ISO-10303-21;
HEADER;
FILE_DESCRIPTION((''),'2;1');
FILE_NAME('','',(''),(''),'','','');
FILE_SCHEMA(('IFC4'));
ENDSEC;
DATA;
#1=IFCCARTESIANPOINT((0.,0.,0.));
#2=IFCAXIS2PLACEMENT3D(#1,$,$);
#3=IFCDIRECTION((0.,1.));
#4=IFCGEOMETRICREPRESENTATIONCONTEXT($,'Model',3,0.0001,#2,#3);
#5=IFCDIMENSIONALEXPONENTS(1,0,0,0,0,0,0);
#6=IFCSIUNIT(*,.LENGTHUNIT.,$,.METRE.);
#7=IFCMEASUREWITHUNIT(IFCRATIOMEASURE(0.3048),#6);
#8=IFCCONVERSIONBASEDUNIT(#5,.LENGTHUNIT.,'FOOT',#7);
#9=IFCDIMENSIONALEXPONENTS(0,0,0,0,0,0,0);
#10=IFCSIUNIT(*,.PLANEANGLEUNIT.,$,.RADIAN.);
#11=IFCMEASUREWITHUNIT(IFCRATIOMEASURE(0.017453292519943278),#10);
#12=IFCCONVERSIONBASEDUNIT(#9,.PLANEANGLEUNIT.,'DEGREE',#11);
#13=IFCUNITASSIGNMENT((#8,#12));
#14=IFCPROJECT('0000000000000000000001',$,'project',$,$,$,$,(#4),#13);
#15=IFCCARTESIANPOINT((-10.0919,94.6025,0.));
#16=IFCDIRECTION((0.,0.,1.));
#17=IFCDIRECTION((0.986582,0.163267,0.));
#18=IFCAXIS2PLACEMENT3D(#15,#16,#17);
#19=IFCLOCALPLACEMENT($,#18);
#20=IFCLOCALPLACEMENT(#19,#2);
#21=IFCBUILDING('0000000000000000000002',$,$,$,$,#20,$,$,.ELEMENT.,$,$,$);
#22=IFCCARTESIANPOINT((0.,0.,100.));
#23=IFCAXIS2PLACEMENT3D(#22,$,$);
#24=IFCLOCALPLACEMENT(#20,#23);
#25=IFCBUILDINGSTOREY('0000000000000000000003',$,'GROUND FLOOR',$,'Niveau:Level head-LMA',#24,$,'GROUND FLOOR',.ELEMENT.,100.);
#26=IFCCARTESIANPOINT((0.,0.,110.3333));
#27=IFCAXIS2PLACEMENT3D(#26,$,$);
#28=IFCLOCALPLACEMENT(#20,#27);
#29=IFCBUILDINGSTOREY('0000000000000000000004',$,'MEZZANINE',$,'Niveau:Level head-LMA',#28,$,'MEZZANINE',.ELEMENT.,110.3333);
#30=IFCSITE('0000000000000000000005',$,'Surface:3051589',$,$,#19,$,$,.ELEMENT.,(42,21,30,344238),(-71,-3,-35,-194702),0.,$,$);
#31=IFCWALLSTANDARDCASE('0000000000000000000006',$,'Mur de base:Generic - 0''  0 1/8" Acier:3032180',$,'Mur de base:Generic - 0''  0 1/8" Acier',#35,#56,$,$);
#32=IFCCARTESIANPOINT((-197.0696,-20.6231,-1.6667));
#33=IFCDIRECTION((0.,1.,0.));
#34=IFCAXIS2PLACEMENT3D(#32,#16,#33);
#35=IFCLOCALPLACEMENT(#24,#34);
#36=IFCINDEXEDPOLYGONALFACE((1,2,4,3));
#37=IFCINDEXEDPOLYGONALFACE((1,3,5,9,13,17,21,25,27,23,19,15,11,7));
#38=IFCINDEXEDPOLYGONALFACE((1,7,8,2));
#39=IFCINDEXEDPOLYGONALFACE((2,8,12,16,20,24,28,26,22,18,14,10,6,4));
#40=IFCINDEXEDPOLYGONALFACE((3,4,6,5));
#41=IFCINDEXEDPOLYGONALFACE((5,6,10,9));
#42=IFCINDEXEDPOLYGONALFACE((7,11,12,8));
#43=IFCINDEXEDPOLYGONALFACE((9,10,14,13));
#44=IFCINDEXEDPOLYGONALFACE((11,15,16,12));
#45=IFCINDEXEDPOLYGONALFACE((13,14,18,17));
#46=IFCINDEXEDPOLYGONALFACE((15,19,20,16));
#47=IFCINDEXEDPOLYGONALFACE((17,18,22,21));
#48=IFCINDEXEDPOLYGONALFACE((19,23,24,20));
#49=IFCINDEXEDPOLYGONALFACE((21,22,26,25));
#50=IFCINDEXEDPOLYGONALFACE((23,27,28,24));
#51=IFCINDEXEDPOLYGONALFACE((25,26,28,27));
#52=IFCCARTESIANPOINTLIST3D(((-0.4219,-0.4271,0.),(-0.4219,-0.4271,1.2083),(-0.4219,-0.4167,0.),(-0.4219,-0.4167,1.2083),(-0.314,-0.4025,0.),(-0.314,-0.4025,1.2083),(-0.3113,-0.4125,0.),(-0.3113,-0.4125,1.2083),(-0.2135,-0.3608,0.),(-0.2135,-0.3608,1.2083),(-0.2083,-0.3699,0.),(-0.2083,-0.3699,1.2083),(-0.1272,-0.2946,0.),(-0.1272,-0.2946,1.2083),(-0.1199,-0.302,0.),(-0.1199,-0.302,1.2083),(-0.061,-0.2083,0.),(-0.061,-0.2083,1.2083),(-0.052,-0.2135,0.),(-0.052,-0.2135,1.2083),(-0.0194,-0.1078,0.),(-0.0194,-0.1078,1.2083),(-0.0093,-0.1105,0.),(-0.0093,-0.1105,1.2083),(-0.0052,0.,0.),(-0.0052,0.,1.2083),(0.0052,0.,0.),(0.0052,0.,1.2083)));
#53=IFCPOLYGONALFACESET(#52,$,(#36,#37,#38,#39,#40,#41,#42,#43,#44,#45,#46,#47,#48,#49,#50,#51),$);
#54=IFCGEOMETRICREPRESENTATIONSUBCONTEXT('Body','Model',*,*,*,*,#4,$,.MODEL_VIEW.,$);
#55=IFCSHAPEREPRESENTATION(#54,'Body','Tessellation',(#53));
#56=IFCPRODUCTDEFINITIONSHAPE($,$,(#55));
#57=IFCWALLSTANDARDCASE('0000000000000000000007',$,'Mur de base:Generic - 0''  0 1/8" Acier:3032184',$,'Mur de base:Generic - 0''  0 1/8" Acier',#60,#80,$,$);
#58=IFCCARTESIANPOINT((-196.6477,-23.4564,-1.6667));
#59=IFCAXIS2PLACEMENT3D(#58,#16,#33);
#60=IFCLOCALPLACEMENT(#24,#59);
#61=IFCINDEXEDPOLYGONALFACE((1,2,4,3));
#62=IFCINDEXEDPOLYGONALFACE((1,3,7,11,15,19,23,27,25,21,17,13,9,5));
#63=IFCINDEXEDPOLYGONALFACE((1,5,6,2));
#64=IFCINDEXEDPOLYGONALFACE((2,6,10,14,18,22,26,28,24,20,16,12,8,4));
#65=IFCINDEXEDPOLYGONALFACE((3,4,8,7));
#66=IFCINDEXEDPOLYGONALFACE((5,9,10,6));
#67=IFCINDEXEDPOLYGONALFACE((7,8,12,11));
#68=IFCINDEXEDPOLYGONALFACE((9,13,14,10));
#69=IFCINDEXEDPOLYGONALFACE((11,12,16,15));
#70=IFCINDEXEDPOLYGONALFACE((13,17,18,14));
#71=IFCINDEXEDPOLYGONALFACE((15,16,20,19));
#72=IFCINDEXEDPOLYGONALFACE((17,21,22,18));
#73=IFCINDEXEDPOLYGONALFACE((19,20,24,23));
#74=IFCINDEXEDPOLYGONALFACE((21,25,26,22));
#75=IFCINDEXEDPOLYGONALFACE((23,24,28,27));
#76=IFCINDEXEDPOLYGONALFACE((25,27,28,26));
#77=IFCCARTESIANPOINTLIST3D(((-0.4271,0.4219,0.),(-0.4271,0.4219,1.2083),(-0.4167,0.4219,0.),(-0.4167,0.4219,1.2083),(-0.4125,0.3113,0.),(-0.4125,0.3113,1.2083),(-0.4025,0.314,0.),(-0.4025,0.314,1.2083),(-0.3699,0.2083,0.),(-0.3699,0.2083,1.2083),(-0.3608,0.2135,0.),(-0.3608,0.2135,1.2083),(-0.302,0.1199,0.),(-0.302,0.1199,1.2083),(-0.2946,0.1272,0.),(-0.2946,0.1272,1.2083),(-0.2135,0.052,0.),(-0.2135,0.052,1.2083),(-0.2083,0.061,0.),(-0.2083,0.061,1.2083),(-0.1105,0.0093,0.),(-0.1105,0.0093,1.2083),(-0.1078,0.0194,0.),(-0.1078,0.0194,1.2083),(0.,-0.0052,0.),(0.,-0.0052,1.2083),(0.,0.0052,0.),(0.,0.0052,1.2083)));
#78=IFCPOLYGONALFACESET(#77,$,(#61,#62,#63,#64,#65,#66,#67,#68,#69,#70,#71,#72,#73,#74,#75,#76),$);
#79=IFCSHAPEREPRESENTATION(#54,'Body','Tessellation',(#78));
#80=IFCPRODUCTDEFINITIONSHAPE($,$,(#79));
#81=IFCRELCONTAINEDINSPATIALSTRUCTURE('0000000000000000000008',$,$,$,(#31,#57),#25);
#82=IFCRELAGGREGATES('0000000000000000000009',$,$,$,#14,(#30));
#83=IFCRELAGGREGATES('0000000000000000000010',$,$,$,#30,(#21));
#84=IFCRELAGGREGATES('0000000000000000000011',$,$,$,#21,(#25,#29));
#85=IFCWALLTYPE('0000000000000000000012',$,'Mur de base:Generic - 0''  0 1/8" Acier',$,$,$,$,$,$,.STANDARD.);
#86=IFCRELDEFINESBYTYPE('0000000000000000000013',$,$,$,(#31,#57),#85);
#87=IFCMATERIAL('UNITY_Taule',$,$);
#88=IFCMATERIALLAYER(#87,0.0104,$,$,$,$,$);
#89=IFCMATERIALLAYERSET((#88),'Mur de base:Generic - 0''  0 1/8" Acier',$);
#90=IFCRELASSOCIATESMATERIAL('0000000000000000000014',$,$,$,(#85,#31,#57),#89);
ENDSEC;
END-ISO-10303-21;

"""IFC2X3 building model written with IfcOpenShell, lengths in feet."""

from ifc_helpers import new_model, entity, si_unit, converted_unit, direction, frame, frame_2d, origin, place, context, subcontext, project, spatial, polyline, circle_curve, parameter, trimmed, segment, composite_curve, outline, extrude, material, layer, layer_set, layer_usage, type_object, element, save


model = new_model("IFC2X3")

# Units and contexts
model_context = context("Model", 3, precision=0.0001, world=origin(), true_north=direction((0.0, 1.0)))
body_context = subcontext(model_context, "Body", "Model", "MODEL_VIEW")
ifc_project = project(units=[converted_unit("LENGTHUNIT", "FOOT", entity("IfcRatioMeasure", 0.3048), si_unit("LENGTHUNIT", "METRE"), dimensions=[1, 0, 0, 0, 0, 0, 0]), converted_unit("PLANEANGLEUNIT", "DEGREE", entity("IfcRatioMeasure", 0.017453292519943278), si_unit("PLANEANGLEUNIT", "RADIAN"), dimensions=[0, 0, 0, 0, 0, 0, 0])], contexts=[model_context])

# Site, building, storey
site_placement = place(None, frame((-10.0919, 94.6025, 0.0), z_axis=(0.0, 0.0, 1.0), x_axis=(0.986582, 0.163267, 0.0)))
site = spatial("IfcSite", under=ifc_project, at=site_placement, Name="Surface:3051589", CompositionType="ELEMENT", RefLatitude=(42, 21, 30, 344238), RefLongitude=(-71, -3, -35, -194702), RefElevation=0.0)
building_placement = place(site_placement, origin())
building = spatial("IfcBuilding", under=site, at=building_placement, CompositionType="ELEMENT")
storey_1_placement = place(building_placement, frame((0.0, 0.0, 100.0)))
storey_1 = spatial("IfcBuildingStorey", under=building, at=storey_1_placement, Name="GROUND FLOOR", ObjectType="Niveau:Level head-LMA", LongName="GROUND FLOOR", CompositionType="ELEMENT", Elevation=100.0)

# Shared definitions
storey_2_placement = place(building_placement, frame((0.0, 0.0, 110.3333)))
storey_2 = spatial("IfcBuildingStorey", under=building, at=storey_2_placement, Name="MEZZANINE", ObjectType="Niveau:Level head-LMA", LongName="MEZZANINE", CompositionType="ELEMENT", Elevation=110.3333)

# Walls
ifc_material_1 = material(Name="UNITY_Taule")
ifc_layer_1 = layer(ifc_material_1, 0.0104)
ifc_layer_set_1 = layer_set([ifc_layer_1], Name="Mur de base:Generic - 0'  0 1/8\" Acier")
ifc_layer_usage_1 = layer_usage(ifc_layer_set_1, "AXIS2", "NEGATIVE", 0.0052)
wall_type_1 = type_object("IfcWallType", Name="Mur de base:Generic - 0'  0 1/8\" Acier", PredefinedType="STANDARD", material=ifc_layer_set_1)
wall_1_placement = place(storey_1_placement, frame((-197.0696, -20.6231, -1.6667), z_axis=(0.0, 0.0, 1.0), x_axis=(0.0, 1.0, 0.0)))
element("IfcWallStandardCase", 1, at=wall_1_placement, inside=storey_1, type_object=wall_type_1, material=ifc_layer_usage_1, Name="Mur de base:Generic - 0'  0 1/8\" Acier:3032180", ObjectType="Mur de base:Generic - 0'  0 1/8\" Acier", context=body_context, shape_type="SweptSolid", body=[
    extrude(outline(composite_curve([segment(trimmed(circle_curve(frame_2d((-0.4219, 0.0), x_axis=(1.0, 0.0)), 0.4271), [parameter(270.0)], [parameter(360.0)], True, "PARAMETER"), True, "CONTINUOUS"), segment(polyline([(0.0052, 0.0), (-0.0052, 0.0)]), True, "CONTINUOUS"), segment(trimmed(circle_curve(frame_2d((-0.4219, 0.0), x_axis=(1.0, 0.0)), 0.4167), [parameter(270.0)], [parameter(360.0)], True, "PARAMETER"), False, "CONTINUOUS"), segment(polyline([(-0.4219, -0.4167), (-0.4219, -0.4271)]), True, "CONTINUOUS")], self_intersect=False)), origin(), (0.0, 0.0, 1.0), 1.2083),
])
ifc_layer_usage_2 = layer_usage(ifc_layer_set_1, "AXIS2", "NEGATIVE", 0.0052)
wall_2_placement = place(storey_1_placement, frame((-196.6477, -23.4564, -1.6667), z_axis=(0.0, 0.0, 1.0), x_axis=(0.0, 1.0, 0.0)))
element("IfcWallStandardCase", 2, at=wall_2_placement, inside=storey_1, type_object=wall_type_1, material=ifc_layer_usage_2, Name="Mur de base:Generic - 0'  0 1/8\" Acier:3032184", ObjectType="Mur de base:Generic - 0'  0 1/8\" Acier", context=body_context, shape_type="SweptSolid", body=[
    extrude(outline(composite_curve([segment(trimmed(circle_curve(frame_2d((0.0, 0.4219), x_axis=(1.0, 0.0)), 0.4271), [parameter(180.0)], [parameter(270.0)], True, "PARAMETER"), True, "CONTINUOUS"), segment(polyline([(0.0, -0.0052), (0.0, 0.0052)]), True, "CONTINUOUS"), segment(trimmed(circle_curve(frame_2d((0.0, 0.4219), x_axis=(1.0, 0.0)), 0.4167), [parameter(180.0)], [parameter(270.0)], True, "PARAMETER"), False, "CONTINUOUS"), segment(polyline([(-0.4167, 0.4219), (-0.4271, 0.4219)]), True, "CONTINUOUS")], self_intersect=False)), origin(), (0.0, 0.0, 1.0), 1.2083),
])

save(model, "model.ifc")
